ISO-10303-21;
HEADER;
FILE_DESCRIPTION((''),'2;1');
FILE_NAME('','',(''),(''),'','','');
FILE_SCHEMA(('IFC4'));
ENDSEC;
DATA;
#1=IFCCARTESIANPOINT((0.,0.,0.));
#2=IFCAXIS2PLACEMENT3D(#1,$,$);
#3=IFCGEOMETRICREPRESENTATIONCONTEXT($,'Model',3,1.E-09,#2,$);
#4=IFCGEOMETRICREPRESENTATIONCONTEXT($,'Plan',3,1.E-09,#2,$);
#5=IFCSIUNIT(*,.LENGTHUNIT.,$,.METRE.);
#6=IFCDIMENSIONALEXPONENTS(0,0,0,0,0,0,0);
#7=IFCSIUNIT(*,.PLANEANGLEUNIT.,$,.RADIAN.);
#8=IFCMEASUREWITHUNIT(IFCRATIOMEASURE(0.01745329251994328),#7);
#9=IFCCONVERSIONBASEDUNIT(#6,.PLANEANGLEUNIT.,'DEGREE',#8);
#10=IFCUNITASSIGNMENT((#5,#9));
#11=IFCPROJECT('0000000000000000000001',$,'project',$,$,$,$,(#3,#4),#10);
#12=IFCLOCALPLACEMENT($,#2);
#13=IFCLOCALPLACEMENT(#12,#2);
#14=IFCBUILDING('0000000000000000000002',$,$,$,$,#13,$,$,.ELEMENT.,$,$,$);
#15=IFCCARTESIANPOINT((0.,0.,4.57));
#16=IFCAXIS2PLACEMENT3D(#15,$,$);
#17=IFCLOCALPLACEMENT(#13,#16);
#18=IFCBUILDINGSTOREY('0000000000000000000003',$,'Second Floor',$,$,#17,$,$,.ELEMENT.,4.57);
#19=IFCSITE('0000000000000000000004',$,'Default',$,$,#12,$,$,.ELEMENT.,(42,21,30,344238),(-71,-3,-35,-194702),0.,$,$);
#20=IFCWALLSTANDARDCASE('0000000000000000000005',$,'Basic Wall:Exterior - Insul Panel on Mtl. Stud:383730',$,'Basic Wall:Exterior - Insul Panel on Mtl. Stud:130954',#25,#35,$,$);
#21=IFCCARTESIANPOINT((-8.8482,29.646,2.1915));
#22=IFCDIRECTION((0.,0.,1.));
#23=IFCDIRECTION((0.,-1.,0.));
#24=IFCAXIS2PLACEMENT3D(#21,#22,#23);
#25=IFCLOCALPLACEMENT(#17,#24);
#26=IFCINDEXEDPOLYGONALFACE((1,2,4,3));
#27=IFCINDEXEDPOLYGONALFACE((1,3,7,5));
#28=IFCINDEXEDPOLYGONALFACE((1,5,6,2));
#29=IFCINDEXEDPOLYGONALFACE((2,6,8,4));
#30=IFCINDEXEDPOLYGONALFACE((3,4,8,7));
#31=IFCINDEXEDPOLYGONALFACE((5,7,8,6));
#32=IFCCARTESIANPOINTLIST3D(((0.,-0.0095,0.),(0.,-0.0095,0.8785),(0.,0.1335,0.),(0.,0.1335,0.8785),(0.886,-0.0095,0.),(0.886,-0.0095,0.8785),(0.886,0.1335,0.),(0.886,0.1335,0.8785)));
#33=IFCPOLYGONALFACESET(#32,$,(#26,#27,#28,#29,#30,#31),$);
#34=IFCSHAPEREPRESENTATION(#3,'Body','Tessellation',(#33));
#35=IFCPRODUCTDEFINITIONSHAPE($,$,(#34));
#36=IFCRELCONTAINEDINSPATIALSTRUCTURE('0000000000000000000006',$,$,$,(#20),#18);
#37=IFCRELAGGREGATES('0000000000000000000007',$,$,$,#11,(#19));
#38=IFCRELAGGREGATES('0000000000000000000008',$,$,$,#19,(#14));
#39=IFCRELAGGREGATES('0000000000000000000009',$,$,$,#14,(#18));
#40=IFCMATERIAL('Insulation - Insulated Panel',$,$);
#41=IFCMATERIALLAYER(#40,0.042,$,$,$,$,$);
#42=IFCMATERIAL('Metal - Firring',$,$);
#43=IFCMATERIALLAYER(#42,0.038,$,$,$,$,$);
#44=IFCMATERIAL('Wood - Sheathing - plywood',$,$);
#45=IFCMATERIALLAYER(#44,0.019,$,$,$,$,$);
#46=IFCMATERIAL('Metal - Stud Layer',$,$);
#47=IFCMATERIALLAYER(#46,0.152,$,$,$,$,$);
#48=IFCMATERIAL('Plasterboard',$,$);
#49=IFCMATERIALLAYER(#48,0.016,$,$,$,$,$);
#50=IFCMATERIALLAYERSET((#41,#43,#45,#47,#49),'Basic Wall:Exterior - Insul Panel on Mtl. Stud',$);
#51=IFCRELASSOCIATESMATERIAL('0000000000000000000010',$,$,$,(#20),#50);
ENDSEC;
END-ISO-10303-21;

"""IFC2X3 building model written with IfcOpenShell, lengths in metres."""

from ifc_helpers import new_model, entity, si_unit, converted_unit, frame, frame_2d, origin, place, context, project, spatial, polyline, rectangle, extrude, clip, bounded_halfspace, material, layer, layer_set, layer_usage, element, save


model = new_model("IFC2X3")

# Units and contexts
model_context = context("Model", 3, precision=1e-09, world=origin())
plan_context = context("Plan", 3, precision=1e-09, world=origin())
ifc_project = project(units=[si_unit("LENGTHUNIT", "METRE"), converted_unit("PLANEANGLEUNIT", "DEGREE", entity("IfcRatioMeasure", 0.01745329251994328), si_unit("PLANEANGLEUNIT", "RADIAN"), dimensions=[0, 0, 0, 0, 0, 0, 0])], contexts=[model_context, plan_context])

# Site, building, storey
site_placement = place(None, origin())
site = spatial("IfcSite", under=ifc_project, at=site_placement, Name="Default", CompositionType="ELEMENT", RefLatitude=(42, 21, 30, 344238), RefLongitude=(-71, -3, -35, -194702), RefElevation=0.0)
building_placement = place(site_placement, origin())
building = spatial("IfcBuilding", under=site, at=building_placement, CompositionType="ELEMENT")
storey_placement = place(building_placement, frame((0.0, 0.0, 4.57)))
storey = spatial("IfcBuildingStorey", under=building, at=storey_placement, Name="Second Floor", CompositionType="ELEMENT", Elevation=4.57)

# Shared definitions
ifc_material_1 = material(Name="Plasterboard")
ifc_material_2 = material(Name="Metal - Stud Layer")

# Wall
ifc_material_3 = material(Name="Insulation - Insulated Panel")
ifc_layer_1 = layer(ifc_material_3, 0.042)
ifc_material_4 = material(Name="Metal - Firring")
ifc_layer_2 = layer(ifc_material_4, 0.038)
ifc_material_5 = material(Name="Wood - Sheathing - plywood")
ifc_layer_3 = layer(ifc_material_5, 0.019)
ifc_layer_4 = layer(ifc_material_2, 0.152)
ifc_layer_5 = layer(ifc_material_1, 0.016)
ifc_layer_set_1 = layer_set([ifc_layer_1, ifc_layer_2, ifc_layer_3, ifc_layer_4, ifc_layer_5], Name="Basic Wall:Exterior - Insul Panel on Mtl. Stud")
ifc_layer_usage_1 = layer_usage(ifc_layer_set_1, "AXIS2", "NEGATIVE", 0.1335)
wall_1_placement = place(storey_placement, frame((-8.8482, 29.646, 2.1915), z_axis=(0.0, 0.0, 1.0), x_axis=(0.0, -1.0, 0.0)))
element("IfcWallStandardCase", 1, at=wall_1_placement, inside=storey, material=ifc_layer_usage_1, Name="Basic Wall:Exterior - Insul Panel on Mtl. Stud:383730", ObjectType="Basic Wall:Exterior - Insul Panel on Mtl. Stud:130954", context=model_context, shape_type="Clipping", body=[
    clip(extrude(rectangle(XDim=0.886, YDim=0.267, at=frame_2d((0.443, 0.0), x_axis=(-1.0, 0.0))), origin(), (0.0, 0.0, 1.0), 0.8785), bounded_halfspace(frame((0.0, -0.0095, 0.0), z_axis=(0.0, 1.0, 0.0), x_axis=(-1.0, 0.0, 0.0)), True, frame((0.0, -0.0095, 0.0), z_axis=(0.0, 1.0, 0.0), x_axis=(-1.0, 0.0, 0.0)), polyline([(0.0, 0.0), (0.0, 0.8785), (-0.3832, 0.8785), (-0.876, 0.8785), (-0.886, 0.8785), (-0.886, 0.0), (0.0, 0.0)]))),
])

save(model, "model.ifc")
